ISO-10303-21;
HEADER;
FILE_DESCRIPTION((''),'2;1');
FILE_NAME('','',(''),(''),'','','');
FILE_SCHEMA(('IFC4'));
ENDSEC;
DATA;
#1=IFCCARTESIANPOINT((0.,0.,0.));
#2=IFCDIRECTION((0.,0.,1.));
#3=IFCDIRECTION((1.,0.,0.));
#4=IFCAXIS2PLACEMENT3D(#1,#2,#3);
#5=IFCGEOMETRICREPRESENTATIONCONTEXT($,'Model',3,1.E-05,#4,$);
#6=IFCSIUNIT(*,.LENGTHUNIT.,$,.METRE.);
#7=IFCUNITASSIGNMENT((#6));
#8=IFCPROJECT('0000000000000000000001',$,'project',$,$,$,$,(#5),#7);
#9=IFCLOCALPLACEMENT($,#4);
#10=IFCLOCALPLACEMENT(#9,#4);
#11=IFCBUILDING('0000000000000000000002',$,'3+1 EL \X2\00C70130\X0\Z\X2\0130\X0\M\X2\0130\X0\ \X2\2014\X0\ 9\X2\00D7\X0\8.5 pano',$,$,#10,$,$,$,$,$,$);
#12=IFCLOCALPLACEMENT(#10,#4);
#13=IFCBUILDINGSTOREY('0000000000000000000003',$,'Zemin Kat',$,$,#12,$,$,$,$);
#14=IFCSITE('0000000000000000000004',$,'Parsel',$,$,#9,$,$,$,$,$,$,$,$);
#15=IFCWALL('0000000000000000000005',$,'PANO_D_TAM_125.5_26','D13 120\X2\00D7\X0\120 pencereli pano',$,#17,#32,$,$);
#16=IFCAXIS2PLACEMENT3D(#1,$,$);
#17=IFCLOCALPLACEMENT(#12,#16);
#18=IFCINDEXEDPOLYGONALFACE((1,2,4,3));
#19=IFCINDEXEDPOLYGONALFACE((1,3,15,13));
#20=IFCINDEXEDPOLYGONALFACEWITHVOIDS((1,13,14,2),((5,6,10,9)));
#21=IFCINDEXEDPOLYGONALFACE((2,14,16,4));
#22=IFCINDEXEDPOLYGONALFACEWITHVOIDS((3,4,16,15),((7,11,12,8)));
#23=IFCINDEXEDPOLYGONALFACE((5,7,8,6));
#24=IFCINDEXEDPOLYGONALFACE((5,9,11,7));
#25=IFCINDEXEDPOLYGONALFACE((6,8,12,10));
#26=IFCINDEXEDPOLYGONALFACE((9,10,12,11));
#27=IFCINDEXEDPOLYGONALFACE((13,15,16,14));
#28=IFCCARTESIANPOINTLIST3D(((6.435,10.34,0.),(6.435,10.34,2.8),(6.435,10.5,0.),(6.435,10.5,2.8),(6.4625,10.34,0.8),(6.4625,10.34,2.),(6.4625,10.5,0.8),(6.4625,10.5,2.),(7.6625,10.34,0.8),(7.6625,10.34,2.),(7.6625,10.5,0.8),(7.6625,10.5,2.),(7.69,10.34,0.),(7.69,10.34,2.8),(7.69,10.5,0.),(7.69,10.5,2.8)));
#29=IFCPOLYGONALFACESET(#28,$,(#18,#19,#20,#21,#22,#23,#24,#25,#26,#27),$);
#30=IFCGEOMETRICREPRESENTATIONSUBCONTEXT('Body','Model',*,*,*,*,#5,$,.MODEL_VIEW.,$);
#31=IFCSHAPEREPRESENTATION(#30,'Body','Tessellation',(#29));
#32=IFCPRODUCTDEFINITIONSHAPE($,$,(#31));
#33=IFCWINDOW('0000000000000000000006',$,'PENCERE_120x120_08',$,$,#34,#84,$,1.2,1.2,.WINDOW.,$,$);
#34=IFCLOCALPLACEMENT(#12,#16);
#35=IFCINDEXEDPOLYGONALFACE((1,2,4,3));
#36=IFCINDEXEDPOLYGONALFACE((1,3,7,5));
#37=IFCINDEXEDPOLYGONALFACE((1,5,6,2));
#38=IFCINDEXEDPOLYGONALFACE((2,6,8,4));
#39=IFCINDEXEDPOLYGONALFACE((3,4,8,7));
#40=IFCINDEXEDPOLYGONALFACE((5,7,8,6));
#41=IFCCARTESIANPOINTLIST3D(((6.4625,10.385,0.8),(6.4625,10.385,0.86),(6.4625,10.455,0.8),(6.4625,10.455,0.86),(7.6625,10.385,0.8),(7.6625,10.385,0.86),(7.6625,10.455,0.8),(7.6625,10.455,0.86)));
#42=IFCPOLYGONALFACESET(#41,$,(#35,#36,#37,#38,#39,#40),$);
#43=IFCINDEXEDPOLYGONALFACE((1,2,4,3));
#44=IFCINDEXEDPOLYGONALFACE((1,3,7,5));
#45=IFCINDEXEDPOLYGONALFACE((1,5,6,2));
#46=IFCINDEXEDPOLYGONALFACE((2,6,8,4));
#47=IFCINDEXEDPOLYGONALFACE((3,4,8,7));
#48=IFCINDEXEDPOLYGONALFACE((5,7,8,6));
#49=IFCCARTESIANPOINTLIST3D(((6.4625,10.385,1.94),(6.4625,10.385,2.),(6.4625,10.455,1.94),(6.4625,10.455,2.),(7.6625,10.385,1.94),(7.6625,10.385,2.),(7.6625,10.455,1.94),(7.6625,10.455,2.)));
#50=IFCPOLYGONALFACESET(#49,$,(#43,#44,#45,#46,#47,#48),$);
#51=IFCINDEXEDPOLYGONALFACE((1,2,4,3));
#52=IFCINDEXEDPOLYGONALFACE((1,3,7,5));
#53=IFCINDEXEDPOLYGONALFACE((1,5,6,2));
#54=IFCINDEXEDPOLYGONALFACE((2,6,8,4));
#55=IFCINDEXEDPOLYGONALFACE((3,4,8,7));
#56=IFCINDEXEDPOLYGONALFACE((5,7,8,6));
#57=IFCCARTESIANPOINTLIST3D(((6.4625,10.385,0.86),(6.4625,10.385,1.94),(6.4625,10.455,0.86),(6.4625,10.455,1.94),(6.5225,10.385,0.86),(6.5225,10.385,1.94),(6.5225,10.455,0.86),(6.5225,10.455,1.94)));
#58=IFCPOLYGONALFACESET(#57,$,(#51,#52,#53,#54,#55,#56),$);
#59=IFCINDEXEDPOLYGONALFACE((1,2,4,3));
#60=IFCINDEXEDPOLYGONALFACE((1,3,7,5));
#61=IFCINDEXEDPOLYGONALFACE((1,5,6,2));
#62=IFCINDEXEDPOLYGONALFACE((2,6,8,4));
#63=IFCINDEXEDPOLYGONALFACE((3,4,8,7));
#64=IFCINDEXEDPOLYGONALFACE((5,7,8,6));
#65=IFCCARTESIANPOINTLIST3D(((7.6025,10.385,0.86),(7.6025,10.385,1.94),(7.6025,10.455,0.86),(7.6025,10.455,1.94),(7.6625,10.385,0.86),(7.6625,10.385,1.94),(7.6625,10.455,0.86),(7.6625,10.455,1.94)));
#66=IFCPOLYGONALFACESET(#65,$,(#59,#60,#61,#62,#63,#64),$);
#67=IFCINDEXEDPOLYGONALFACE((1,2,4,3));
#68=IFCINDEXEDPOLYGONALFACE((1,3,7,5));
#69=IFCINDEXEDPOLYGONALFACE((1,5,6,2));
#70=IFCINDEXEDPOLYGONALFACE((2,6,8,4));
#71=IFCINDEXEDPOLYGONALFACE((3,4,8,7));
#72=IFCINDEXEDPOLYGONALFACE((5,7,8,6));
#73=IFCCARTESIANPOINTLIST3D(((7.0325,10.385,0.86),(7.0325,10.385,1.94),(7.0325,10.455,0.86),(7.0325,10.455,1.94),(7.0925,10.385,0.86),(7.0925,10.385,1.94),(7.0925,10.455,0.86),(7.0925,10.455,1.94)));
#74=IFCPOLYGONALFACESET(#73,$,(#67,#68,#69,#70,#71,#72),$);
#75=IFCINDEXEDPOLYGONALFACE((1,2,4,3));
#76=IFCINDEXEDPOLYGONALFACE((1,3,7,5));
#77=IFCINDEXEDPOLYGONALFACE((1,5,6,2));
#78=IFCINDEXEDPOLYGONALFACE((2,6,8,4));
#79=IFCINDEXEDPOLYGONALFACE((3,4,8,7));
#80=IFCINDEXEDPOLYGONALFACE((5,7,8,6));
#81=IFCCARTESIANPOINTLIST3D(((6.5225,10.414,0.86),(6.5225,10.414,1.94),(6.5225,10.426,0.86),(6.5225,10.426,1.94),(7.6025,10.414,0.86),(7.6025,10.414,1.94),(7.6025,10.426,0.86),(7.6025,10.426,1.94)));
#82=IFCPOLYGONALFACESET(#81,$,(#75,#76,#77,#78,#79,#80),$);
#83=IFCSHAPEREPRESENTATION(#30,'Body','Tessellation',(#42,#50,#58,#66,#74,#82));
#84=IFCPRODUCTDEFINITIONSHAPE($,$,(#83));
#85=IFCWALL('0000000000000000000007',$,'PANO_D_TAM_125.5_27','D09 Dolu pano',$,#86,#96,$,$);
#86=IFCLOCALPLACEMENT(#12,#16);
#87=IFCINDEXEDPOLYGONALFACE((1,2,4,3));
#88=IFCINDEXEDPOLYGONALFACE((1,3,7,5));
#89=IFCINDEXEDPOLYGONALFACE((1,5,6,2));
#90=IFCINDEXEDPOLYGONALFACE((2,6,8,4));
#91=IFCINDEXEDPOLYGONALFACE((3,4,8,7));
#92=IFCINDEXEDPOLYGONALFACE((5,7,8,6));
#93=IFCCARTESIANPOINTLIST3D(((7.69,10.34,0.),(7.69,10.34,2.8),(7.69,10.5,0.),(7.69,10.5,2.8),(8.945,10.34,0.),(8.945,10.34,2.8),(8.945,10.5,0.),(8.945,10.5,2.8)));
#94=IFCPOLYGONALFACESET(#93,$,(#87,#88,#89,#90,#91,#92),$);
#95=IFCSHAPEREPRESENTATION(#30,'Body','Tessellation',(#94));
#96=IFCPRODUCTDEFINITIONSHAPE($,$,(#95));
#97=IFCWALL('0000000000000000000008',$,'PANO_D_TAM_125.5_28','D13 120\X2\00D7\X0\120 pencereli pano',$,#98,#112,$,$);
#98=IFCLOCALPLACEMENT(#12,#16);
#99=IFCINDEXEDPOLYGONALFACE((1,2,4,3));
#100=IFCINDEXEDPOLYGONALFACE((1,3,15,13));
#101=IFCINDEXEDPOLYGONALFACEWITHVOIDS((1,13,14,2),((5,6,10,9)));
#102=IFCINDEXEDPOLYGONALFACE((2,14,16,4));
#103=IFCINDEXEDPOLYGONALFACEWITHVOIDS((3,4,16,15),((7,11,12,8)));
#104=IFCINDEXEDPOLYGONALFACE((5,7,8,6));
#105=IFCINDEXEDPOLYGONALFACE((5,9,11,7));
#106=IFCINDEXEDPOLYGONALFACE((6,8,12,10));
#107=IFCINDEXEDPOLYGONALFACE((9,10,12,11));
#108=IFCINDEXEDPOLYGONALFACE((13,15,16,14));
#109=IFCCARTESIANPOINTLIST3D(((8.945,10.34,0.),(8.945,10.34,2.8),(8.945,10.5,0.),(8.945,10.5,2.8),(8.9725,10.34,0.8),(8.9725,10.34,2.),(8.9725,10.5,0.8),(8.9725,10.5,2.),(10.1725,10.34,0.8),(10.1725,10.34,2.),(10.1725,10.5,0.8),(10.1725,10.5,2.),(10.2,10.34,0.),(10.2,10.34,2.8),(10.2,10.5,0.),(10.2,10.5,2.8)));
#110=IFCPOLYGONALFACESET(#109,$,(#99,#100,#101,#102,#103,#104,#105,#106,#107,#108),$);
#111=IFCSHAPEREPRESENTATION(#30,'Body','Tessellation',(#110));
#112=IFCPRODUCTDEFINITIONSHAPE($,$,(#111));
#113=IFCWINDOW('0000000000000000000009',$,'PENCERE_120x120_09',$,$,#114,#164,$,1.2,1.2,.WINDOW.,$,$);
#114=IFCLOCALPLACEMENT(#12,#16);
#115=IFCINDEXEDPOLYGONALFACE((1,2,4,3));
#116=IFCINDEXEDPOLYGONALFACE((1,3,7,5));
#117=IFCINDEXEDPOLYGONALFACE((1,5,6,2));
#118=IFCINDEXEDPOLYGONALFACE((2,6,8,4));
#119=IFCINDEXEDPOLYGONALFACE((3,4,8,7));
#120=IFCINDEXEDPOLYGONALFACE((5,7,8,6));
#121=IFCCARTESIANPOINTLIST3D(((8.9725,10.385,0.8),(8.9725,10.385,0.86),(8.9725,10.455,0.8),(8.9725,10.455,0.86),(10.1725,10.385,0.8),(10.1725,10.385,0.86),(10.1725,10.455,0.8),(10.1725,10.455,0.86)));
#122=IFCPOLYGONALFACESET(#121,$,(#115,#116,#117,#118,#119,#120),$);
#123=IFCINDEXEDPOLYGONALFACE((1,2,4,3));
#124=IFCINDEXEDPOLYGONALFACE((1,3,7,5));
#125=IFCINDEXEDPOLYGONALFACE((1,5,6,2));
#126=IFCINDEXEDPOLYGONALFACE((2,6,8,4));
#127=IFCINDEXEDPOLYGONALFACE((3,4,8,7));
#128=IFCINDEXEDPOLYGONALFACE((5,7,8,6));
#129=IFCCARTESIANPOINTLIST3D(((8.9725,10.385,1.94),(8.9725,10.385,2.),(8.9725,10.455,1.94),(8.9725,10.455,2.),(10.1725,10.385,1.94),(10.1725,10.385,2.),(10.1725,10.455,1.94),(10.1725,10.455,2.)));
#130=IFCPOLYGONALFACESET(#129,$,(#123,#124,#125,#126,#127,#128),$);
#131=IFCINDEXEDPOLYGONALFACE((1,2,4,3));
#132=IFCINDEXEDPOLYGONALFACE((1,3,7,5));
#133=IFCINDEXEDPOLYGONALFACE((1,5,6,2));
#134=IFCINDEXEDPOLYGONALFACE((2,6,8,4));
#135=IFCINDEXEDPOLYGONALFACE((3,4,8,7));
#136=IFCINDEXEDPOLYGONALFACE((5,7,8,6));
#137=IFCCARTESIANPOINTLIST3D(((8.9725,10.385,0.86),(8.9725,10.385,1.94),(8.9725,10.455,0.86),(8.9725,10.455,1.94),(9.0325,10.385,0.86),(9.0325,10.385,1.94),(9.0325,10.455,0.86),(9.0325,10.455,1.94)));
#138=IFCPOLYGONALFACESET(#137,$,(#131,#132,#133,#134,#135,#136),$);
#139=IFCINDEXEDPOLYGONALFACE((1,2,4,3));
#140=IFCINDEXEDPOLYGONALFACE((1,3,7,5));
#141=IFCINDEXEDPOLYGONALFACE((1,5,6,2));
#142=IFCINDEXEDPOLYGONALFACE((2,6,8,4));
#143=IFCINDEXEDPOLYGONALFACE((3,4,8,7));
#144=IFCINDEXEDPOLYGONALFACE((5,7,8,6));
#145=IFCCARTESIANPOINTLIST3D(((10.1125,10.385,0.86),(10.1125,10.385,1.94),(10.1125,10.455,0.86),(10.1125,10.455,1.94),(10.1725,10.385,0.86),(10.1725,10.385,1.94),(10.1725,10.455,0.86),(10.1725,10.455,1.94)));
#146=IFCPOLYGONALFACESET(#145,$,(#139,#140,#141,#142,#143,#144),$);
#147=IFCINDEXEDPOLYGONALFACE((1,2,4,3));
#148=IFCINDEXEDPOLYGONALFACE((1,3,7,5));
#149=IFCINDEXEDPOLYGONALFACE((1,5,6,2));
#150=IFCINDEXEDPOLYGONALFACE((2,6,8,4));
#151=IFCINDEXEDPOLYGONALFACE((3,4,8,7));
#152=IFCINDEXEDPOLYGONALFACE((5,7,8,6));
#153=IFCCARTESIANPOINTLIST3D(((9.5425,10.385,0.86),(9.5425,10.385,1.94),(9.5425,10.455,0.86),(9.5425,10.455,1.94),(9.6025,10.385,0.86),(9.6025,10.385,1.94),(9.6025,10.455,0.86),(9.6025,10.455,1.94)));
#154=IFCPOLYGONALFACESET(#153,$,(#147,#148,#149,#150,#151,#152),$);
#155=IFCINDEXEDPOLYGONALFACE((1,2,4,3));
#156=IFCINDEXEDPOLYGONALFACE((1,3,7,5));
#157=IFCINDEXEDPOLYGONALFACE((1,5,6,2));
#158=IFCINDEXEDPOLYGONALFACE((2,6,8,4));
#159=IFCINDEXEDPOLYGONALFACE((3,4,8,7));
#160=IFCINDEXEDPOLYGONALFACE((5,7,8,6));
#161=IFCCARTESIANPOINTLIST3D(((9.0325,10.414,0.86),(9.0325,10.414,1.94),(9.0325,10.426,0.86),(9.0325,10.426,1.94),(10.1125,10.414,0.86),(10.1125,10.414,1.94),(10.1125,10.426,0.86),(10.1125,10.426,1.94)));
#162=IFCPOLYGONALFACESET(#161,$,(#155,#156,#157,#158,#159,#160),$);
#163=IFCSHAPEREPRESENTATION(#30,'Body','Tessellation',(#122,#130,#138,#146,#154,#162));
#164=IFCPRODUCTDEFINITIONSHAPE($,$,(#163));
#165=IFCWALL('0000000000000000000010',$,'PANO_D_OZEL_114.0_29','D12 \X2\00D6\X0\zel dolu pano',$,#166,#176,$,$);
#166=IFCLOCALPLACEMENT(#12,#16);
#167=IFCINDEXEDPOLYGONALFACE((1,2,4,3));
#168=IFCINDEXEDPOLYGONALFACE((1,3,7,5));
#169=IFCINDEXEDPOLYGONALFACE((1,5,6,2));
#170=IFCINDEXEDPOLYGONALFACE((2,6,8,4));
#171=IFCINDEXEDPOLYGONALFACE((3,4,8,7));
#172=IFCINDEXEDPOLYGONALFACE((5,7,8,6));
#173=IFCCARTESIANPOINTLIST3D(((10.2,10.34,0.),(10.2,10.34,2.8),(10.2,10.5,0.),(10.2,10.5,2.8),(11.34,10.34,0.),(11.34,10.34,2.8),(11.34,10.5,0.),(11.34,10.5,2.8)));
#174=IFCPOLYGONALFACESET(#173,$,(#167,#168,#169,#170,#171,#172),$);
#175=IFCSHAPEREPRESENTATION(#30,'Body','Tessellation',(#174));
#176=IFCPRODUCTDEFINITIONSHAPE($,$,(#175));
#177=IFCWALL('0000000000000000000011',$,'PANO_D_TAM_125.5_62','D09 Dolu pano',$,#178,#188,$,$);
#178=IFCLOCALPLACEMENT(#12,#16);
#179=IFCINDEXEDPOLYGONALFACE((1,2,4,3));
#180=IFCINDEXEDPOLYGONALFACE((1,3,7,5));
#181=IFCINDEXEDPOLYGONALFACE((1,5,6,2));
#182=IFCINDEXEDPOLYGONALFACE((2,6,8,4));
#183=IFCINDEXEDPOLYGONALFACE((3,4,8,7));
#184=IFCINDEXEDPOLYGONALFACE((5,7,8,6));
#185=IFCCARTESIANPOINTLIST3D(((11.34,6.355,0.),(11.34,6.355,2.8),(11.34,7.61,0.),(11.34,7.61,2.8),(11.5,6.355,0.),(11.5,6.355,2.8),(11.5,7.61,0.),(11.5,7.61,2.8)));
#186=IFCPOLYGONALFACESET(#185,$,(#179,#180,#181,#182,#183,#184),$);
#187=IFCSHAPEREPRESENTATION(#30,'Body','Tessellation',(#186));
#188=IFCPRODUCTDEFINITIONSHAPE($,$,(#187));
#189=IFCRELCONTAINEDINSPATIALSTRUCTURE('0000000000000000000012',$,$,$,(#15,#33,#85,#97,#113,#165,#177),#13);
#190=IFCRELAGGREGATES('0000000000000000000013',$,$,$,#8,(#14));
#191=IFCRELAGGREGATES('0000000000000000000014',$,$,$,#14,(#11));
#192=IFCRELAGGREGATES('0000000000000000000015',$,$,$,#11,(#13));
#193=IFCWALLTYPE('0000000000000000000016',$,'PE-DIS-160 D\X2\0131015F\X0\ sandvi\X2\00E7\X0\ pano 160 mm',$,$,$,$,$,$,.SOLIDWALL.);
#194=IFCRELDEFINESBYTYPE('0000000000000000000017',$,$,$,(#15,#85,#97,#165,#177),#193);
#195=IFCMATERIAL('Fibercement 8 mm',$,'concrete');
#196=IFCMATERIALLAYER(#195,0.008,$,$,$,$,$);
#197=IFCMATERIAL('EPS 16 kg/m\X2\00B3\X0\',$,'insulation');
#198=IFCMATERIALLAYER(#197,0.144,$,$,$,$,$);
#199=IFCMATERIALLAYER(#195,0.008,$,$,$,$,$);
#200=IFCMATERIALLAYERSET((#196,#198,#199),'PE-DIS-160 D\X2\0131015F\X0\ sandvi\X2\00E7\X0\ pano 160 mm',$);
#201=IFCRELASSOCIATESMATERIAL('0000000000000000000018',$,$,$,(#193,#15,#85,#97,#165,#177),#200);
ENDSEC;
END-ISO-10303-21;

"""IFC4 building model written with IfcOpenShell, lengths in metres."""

from ifc_helpers import new_model, si_unit, frame, origin_with_axes, place, context, subcontext, project, spatial, line, indexed_curve, outline, extrude, material, layer, layer_set, layer_usage, type_object, element, fill, save


model = new_model("IFC4")

# Units and contexts
model_context = context("Model", 3, precision=1e-05, world=origin_with_axes())
body_context = subcontext(model_context, "Body", "Model", "MODEL_VIEW")
ifc_project = project(units=[si_unit("LENGTHUNIT", "METRE")], contexts=[model_context])

# Site, building, storey
site_placement = place(None, origin_with_axes())
site = spatial("IfcSite", under=ifc_project, at=site_placement, Name="Parsel")
building_placement = place(site_placement, origin_with_axes())
building = spatial("IfcBuilding", under=site, at=building_placement, Name="3+1 EL ÇİZİMİ — 9×8.5 pano")
storey_placement = place(building_placement, origin_with_axes())
storey = spatial("IfcBuildingStorey", under=building, at=storey_placement, Name="Zemin Kat")

# Wall, opening, window
ifc_material_1 = material(Name="Fibercement 8 mm", Category="concrete")
ifc_layer_1 = layer(ifc_material_1, 0.008)
ifc_material_2 = material(Name="EPS 16 kg/m³", Category="insulation")
ifc_layer_2 = layer(ifc_material_2, 0.144)
ifc_layer_3 = layer(ifc_material_1, 0.008)
ifc_layer_set_1 = layer_set([ifc_layer_1, ifc_layer_2, ifc_layer_3], Name="PE-DIS-160 Dış sandviç pano 160 mm")
ifc_layer_usage_1 = layer_usage(ifc_layer_set_1, "AXIS2", "POSITIVE", 0.0)
wall_type_1 = type_object("IfcWallType", Name="PE-DIS-160 Dış sandviç pano 160 mm", PredefinedType="SOLIDWALL", material=ifc_layer_set_1)
wall_1_placement = place(storey_placement, frame((6.435, 10.34, 0.0), z_axis=(0.0, 0.0, 1.0), x_axis=(1.0, 0.0, 0.0)))
wall_1 = element("IfcWall", 1, at=wall_1_placement, inside=storey, type_object=wall_type_1, material=ifc_layer_usage_1, Name="PANO_D_TAM_125.5_26", Description="D13 120×120 pencereli pano", context=body_context, shape_type="SweptSolid", body=[
    extrude(outline(indexed_curve([(0.0, 0.0), (1.255, 0.0), (1.255, 0.16), (0.0, 0.16)], segments=[line(1, 2, 3, 4, 1)])), origin_with_axes(), (0.0, 0.0, 1.0), 2.8),
])
opening_1_placement = place(wall_1_placement, origin_with_axes())
opening_1 = element("IfcOpeningElement", 2, at=opening_1_placement, cuts=wall_1, PredefinedType="OPENING", context=body_context, shape_type="SweptSolid", body=[
    extrude(outline(indexed_curve([(0.0, 0.0), (1.2, 0.0), (1.2, 0.2), (0.0, 0.2)], segments=[line(1, 2, 3, 4, 1)])), frame((0.0275, -0.02, 0.8), z_axis=(0.0, 0.0, 1.0), x_axis=(1.0, 0.0, 0.0)), (0.0, 0.0, 1.0), 1.2),
])
window_1_placement = place(storey_placement, frame((6.435, 10.34, 0.0), z_axis=(0.0, 0.0, 1.0), x_axis=(1.0, 0.0, 0.0)))
window_1 = element("IfcWindow", 3, at=window_1_placement, inside=storey, Name="PENCERE_120x120_08", OverallHeight=1.2, OverallWidth=1.2, PredefinedType="WINDOW", context=body_context, shape_type="SweptSolid", body=[
    extrude(outline(indexed_curve([(0.0, 0.0), (1.2, 0.0), (1.2, 0.07), (0.0, 0.07)], segments=[line(1, 2, 3, 4, 1)])), frame((0.0275, 0.045, 0.8), z_axis=(0.0, 0.0, 1.0), x_axis=(1.0, 0.0, 0.0)), (0.0, 0.0, 1.0), 0.06),
    extrude(outline(indexed_curve([(0.0, 0.0), (1.2, 0.0), (1.2, 0.07), (0.0, 0.07)], segments=[line(1, 2, 3, 4, 1)])), frame((0.0275, 0.045, 1.94), z_axis=(0.0, 0.0, 1.0), x_axis=(1.0, 0.0, 0.0)), (0.0, 0.0, 1.0), 0.06),
    extrude(outline(indexed_curve([(0.0, 0.0), (0.06, 0.0), (0.06, 0.07), (0.0, 0.07)], segments=[line(1, 2, 3, 4, 1)])), frame((0.0275, 0.045, 0.86), z_axis=(0.0, 0.0, 1.0), x_axis=(1.0, 0.0, 0.0)), (0.0, 0.0, 1.0), 1.08),
    extrude(outline(indexed_curve([(0.0, 0.0), (0.06, 0.0), (0.06, 0.07), (0.0, 0.07)], segments=[line(1, 2, 3, 4, 1)])), frame((1.1675, 0.045, 0.86), z_axis=(0.0, 0.0, 1.0), x_axis=(1.0, 0.0, 0.0)), (0.0, 0.0, 1.0), 1.08),
    extrude(outline(indexed_curve([(0.0, 0.0), (0.06, 0.0), (0.06, 0.07), (0.0, 0.07)], segments=[line(1, 2, 3, 4, 1)])), frame((0.5975, 0.045, 0.86), z_axis=(0.0, 0.0, 1.0), x_axis=(1.0, 0.0, 0.0)), (0.0, 0.0, 1.0), 1.08),
    extrude(outline(indexed_curve([(0.0, 0.0), (1.08, 0.0), (1.08, 0.012), (0.0, 0.012)], segments=[line(1, 2, 3, 4, 1)])), frame((0.0875, 0.074, 0.86), z_axis=(0.0, 0.0, 1.0), x_axis=(1.0, 0.0, 0.0)), (0.0, 0.0, 1.0), 1.08),
])
fill(opening_1, window_1)

# Wall
ifc_layer_usage_2 = layer_usage(ifc_layer_set_1, "AXIS2", "POSITIVE", 0.0)
wall_2_placement = place(storey_placement, frame((7.69, 10.34, 0.0), z_axis=(0.0, 0.0, 1.0), x_axis=(1.0, 0.0, 0.0)))
element("IfcWall", 4, at=wall_2_placement, inside=storey, type_object=wall_type_1, material=ifc_layer_usage_2, Name="PANO_D_TAM_125.5_27", Description="D09 Dolu pano", context=body_context, shape_type="SweptSolid", body=[
    extrude(outline(indexed_curve([(0.0, 0.0), (1.255, 0.0), (1.255, 0.16), (0.0, 0.16)], segments=[line(1, 2, 3, 4, 1)])), origin_with_axes(), (0.0, 0.0, 1.0), 2.8),
])

# Wall, opening, window
ifc_layer_usage_3 = layer_usage(ifc_layer_set_1, "AXIS2", "POSITIVE", 0.0)
wall_3_placement = place(storey_placement, frame((8.945, 10.34, 0.0), z_axis=(0.0, 0.0, 1.0), x_axis=(1.0, 0.0, 0.0)))
wall_3 = element("IfcWall", 5, at=wall_3_placement, inside=storey, type_object=wall_type_1, material=ifc_layer_usage_3, Name="PANO_D_TAM_125.5_28", Description="D13 120×120 pencereli pano", context=body_context, shape_type="SweptSolid", body=[
    extrude(outline(indexed_curve([(0.0, 0.0), (1.255, 0.0), (1.255, 0.16), (0.0, 0.16)], segments=[line(1, 2, 3, 4, 1)])), origin_with_axes(), (0.0, 0.0, 1.0), 2.8),
])
opening_2_placement = place(wall_3_placement, origin_with_axes())
opening_2 = element("IfcOpeningElement", 6, at=opening_2_placement, cuts=wall_3, PredefinedType="OPENING", context=body_context, shape_type="SweptSolid", body=[
    extrude(outline(indexed_curve([(0.0, 0.0), (1.2, 0.0), (1.2, 0.2), (0.0, 0.2)], segments=[line(1, 2, 3, 4, 1)])), frame((0.0275, -0.02, 0.8), z_axis=(0.0, 0.0, 1.0), x_axis=(1.0, 0.0, 0.0)), (0.0, 0.0, 1.0), 1.2),
])
window_2_placement = place(storey_placement, frame((8.945, 10.34, 0.0), z_axis=(0.0, 0.0, 1.0), x_axis=(1.0, 0.0, 0.0)))
window_2 = element("IfcWindow", 7, at=window_2_placement, inside=storey, Name="PENCERE_120x120_09", OverallHeight=1.2, OverallWidth=1.2, PredefinedType="WINDOW", context=body_context, shape_type="SweptSolid", body=[
    extrude(outline(indexed_curve([(0.0, 0.0), (1.2, 0.0), (1.2, 0.07), (0.0, 0.07)], segments=[line(1, 2, 3, 4, 1)])), frame((0.0275, 0.045, 0.8), z_axis=(0.0, 0.0, 1.0), x_axis=(1.0, 0.0, 0.0)), (0.0, 0.0, 1.0), 0.06),
    extrude(outline(indexed_curve([(0.0, 0.0), (1.2, 0.0), (1.2, 0.07), (0.0, 0.07)], segments=[line(1, 2, 3, 4, 1)])), frame((0.0275, 0.045, 1.94), z_axis=(0.0, 0.0, 1.0), x_axis=(1.0, 0.0, 0.0)), (0.0, 0.0, 1.0), 0.06),
    extrude(outline(indexed_curve([(0.0, 0.0), (0.06, 0.0), (0.06, 0.07), (0.0, 0.07)], segments=[line(1, 2, 3, 4, 1)])), frame((0.0275, 0.045, 0.86), z_axis=(0.0, 0.0, 1.0), x_axis=(1.0, 0.0, 0.0)), (0.0, 0.0, 1.0), 1.08),
    extrude(outline(indexed_curve([(0.0, 0.0), (0.06, 0.0), (0.06, 0.07), (0.0, 0.07)], segments=[line(1, 2, 3, 4, 1)])), frame((1.1675, 0.045, 0.86), z_axis=(0.0, 0.0, 1.0), x_axis=(1.0, 0.0, 0.0)), (0.0, 0.0, 1.0), 1.08),
    extrude(outline(indexed_curve([(0.0, 0.0), (0.06, 0.0), (0.06, 0.07), (0.0, 0.07)], segments=[line(1, 2, 3, 4, 1)])), frame((0.5975, 0.045, 0.86), z_axis=(0.0, 0.0, 1.0), x_axis=(1.0, 0.0, 0.0)), (0.0, 0.0, 1.0), 1.08),
    extrude(outline(indexed_curve([(0.0, 0.0), (1.08, 0.0), (1.08, 0.012), (0.0, 0.012)], segments=[line(1, 2, 3, 4, 1)])), frame((0.0875, 0.074, 0.86), z_axis=(0.0, 0.0, 1.0), x_axis=(1.0, 0.0, 0.0)), (0.0, 0.0, 1.0), 1.08),
])
fill(opening_2, window_2)

# Walls
ifc_layer_usage_4 = layer_usage(ifc_layer_set_1, "AXIS2", "POSITIVE", 0.0)
wall_4_placement = place(storey_placement, frame((10.2, 10.34, 0.0), z_axis=(0.0, 0.0, 1.0), x_axis=(1.0, 0.0, 0.0)))
element("IfcWall", 8, at=wall_4_placement, inside=storey, type_object=wall_type_1, material=ifc_layer_usage_4, Name="PANO_D_OZEL_114.0_29", Description="D12 Özel dolu pano", context=body_context, shape_type="SweptSolid", body=[
    extrude(outline(indexed_curve([(0.0, 0.0), (1.14, 0.0), (1.14, 0.16), (0.0, 0.16)], segments=[line(1, 2, 3, 4, 1)])), origin_with_axes(), (0.0, 0.0, 1.0), 2.8),
])
ifc_layer_usage_5 = layer_usage(ifc_layer_set_1, "AXIS2", "POSITIVE", 0.0)
wall_5_placement = place(storey_placement, frame((11.5, 6.355, 0.0), z_axis=(0.0, 0.0, 1.0), x_axis=(0.0, 1.0, 0.0)))
element("IfcWall", 9, at=wall_5_placement, inside=storey, type_object=wall_type_1, material=ifc_layer_usage_5, Name="PANO_D_TAM_125.5_62", Description="D09 Dolu pano", context=body_context, shape_type="SweptSolid", body=[
    extrude(outline(indexed_curve([(0.0, 0.0), (1.255, 0.0), (1.255, 0.16), (0.0, 0.16)], segments=[line(1, 2, 3, 4, 1)])), origin_with_axes(), (0.0, 0.0, 1.0), 2.8),
])

save(model, "model.ifc")
